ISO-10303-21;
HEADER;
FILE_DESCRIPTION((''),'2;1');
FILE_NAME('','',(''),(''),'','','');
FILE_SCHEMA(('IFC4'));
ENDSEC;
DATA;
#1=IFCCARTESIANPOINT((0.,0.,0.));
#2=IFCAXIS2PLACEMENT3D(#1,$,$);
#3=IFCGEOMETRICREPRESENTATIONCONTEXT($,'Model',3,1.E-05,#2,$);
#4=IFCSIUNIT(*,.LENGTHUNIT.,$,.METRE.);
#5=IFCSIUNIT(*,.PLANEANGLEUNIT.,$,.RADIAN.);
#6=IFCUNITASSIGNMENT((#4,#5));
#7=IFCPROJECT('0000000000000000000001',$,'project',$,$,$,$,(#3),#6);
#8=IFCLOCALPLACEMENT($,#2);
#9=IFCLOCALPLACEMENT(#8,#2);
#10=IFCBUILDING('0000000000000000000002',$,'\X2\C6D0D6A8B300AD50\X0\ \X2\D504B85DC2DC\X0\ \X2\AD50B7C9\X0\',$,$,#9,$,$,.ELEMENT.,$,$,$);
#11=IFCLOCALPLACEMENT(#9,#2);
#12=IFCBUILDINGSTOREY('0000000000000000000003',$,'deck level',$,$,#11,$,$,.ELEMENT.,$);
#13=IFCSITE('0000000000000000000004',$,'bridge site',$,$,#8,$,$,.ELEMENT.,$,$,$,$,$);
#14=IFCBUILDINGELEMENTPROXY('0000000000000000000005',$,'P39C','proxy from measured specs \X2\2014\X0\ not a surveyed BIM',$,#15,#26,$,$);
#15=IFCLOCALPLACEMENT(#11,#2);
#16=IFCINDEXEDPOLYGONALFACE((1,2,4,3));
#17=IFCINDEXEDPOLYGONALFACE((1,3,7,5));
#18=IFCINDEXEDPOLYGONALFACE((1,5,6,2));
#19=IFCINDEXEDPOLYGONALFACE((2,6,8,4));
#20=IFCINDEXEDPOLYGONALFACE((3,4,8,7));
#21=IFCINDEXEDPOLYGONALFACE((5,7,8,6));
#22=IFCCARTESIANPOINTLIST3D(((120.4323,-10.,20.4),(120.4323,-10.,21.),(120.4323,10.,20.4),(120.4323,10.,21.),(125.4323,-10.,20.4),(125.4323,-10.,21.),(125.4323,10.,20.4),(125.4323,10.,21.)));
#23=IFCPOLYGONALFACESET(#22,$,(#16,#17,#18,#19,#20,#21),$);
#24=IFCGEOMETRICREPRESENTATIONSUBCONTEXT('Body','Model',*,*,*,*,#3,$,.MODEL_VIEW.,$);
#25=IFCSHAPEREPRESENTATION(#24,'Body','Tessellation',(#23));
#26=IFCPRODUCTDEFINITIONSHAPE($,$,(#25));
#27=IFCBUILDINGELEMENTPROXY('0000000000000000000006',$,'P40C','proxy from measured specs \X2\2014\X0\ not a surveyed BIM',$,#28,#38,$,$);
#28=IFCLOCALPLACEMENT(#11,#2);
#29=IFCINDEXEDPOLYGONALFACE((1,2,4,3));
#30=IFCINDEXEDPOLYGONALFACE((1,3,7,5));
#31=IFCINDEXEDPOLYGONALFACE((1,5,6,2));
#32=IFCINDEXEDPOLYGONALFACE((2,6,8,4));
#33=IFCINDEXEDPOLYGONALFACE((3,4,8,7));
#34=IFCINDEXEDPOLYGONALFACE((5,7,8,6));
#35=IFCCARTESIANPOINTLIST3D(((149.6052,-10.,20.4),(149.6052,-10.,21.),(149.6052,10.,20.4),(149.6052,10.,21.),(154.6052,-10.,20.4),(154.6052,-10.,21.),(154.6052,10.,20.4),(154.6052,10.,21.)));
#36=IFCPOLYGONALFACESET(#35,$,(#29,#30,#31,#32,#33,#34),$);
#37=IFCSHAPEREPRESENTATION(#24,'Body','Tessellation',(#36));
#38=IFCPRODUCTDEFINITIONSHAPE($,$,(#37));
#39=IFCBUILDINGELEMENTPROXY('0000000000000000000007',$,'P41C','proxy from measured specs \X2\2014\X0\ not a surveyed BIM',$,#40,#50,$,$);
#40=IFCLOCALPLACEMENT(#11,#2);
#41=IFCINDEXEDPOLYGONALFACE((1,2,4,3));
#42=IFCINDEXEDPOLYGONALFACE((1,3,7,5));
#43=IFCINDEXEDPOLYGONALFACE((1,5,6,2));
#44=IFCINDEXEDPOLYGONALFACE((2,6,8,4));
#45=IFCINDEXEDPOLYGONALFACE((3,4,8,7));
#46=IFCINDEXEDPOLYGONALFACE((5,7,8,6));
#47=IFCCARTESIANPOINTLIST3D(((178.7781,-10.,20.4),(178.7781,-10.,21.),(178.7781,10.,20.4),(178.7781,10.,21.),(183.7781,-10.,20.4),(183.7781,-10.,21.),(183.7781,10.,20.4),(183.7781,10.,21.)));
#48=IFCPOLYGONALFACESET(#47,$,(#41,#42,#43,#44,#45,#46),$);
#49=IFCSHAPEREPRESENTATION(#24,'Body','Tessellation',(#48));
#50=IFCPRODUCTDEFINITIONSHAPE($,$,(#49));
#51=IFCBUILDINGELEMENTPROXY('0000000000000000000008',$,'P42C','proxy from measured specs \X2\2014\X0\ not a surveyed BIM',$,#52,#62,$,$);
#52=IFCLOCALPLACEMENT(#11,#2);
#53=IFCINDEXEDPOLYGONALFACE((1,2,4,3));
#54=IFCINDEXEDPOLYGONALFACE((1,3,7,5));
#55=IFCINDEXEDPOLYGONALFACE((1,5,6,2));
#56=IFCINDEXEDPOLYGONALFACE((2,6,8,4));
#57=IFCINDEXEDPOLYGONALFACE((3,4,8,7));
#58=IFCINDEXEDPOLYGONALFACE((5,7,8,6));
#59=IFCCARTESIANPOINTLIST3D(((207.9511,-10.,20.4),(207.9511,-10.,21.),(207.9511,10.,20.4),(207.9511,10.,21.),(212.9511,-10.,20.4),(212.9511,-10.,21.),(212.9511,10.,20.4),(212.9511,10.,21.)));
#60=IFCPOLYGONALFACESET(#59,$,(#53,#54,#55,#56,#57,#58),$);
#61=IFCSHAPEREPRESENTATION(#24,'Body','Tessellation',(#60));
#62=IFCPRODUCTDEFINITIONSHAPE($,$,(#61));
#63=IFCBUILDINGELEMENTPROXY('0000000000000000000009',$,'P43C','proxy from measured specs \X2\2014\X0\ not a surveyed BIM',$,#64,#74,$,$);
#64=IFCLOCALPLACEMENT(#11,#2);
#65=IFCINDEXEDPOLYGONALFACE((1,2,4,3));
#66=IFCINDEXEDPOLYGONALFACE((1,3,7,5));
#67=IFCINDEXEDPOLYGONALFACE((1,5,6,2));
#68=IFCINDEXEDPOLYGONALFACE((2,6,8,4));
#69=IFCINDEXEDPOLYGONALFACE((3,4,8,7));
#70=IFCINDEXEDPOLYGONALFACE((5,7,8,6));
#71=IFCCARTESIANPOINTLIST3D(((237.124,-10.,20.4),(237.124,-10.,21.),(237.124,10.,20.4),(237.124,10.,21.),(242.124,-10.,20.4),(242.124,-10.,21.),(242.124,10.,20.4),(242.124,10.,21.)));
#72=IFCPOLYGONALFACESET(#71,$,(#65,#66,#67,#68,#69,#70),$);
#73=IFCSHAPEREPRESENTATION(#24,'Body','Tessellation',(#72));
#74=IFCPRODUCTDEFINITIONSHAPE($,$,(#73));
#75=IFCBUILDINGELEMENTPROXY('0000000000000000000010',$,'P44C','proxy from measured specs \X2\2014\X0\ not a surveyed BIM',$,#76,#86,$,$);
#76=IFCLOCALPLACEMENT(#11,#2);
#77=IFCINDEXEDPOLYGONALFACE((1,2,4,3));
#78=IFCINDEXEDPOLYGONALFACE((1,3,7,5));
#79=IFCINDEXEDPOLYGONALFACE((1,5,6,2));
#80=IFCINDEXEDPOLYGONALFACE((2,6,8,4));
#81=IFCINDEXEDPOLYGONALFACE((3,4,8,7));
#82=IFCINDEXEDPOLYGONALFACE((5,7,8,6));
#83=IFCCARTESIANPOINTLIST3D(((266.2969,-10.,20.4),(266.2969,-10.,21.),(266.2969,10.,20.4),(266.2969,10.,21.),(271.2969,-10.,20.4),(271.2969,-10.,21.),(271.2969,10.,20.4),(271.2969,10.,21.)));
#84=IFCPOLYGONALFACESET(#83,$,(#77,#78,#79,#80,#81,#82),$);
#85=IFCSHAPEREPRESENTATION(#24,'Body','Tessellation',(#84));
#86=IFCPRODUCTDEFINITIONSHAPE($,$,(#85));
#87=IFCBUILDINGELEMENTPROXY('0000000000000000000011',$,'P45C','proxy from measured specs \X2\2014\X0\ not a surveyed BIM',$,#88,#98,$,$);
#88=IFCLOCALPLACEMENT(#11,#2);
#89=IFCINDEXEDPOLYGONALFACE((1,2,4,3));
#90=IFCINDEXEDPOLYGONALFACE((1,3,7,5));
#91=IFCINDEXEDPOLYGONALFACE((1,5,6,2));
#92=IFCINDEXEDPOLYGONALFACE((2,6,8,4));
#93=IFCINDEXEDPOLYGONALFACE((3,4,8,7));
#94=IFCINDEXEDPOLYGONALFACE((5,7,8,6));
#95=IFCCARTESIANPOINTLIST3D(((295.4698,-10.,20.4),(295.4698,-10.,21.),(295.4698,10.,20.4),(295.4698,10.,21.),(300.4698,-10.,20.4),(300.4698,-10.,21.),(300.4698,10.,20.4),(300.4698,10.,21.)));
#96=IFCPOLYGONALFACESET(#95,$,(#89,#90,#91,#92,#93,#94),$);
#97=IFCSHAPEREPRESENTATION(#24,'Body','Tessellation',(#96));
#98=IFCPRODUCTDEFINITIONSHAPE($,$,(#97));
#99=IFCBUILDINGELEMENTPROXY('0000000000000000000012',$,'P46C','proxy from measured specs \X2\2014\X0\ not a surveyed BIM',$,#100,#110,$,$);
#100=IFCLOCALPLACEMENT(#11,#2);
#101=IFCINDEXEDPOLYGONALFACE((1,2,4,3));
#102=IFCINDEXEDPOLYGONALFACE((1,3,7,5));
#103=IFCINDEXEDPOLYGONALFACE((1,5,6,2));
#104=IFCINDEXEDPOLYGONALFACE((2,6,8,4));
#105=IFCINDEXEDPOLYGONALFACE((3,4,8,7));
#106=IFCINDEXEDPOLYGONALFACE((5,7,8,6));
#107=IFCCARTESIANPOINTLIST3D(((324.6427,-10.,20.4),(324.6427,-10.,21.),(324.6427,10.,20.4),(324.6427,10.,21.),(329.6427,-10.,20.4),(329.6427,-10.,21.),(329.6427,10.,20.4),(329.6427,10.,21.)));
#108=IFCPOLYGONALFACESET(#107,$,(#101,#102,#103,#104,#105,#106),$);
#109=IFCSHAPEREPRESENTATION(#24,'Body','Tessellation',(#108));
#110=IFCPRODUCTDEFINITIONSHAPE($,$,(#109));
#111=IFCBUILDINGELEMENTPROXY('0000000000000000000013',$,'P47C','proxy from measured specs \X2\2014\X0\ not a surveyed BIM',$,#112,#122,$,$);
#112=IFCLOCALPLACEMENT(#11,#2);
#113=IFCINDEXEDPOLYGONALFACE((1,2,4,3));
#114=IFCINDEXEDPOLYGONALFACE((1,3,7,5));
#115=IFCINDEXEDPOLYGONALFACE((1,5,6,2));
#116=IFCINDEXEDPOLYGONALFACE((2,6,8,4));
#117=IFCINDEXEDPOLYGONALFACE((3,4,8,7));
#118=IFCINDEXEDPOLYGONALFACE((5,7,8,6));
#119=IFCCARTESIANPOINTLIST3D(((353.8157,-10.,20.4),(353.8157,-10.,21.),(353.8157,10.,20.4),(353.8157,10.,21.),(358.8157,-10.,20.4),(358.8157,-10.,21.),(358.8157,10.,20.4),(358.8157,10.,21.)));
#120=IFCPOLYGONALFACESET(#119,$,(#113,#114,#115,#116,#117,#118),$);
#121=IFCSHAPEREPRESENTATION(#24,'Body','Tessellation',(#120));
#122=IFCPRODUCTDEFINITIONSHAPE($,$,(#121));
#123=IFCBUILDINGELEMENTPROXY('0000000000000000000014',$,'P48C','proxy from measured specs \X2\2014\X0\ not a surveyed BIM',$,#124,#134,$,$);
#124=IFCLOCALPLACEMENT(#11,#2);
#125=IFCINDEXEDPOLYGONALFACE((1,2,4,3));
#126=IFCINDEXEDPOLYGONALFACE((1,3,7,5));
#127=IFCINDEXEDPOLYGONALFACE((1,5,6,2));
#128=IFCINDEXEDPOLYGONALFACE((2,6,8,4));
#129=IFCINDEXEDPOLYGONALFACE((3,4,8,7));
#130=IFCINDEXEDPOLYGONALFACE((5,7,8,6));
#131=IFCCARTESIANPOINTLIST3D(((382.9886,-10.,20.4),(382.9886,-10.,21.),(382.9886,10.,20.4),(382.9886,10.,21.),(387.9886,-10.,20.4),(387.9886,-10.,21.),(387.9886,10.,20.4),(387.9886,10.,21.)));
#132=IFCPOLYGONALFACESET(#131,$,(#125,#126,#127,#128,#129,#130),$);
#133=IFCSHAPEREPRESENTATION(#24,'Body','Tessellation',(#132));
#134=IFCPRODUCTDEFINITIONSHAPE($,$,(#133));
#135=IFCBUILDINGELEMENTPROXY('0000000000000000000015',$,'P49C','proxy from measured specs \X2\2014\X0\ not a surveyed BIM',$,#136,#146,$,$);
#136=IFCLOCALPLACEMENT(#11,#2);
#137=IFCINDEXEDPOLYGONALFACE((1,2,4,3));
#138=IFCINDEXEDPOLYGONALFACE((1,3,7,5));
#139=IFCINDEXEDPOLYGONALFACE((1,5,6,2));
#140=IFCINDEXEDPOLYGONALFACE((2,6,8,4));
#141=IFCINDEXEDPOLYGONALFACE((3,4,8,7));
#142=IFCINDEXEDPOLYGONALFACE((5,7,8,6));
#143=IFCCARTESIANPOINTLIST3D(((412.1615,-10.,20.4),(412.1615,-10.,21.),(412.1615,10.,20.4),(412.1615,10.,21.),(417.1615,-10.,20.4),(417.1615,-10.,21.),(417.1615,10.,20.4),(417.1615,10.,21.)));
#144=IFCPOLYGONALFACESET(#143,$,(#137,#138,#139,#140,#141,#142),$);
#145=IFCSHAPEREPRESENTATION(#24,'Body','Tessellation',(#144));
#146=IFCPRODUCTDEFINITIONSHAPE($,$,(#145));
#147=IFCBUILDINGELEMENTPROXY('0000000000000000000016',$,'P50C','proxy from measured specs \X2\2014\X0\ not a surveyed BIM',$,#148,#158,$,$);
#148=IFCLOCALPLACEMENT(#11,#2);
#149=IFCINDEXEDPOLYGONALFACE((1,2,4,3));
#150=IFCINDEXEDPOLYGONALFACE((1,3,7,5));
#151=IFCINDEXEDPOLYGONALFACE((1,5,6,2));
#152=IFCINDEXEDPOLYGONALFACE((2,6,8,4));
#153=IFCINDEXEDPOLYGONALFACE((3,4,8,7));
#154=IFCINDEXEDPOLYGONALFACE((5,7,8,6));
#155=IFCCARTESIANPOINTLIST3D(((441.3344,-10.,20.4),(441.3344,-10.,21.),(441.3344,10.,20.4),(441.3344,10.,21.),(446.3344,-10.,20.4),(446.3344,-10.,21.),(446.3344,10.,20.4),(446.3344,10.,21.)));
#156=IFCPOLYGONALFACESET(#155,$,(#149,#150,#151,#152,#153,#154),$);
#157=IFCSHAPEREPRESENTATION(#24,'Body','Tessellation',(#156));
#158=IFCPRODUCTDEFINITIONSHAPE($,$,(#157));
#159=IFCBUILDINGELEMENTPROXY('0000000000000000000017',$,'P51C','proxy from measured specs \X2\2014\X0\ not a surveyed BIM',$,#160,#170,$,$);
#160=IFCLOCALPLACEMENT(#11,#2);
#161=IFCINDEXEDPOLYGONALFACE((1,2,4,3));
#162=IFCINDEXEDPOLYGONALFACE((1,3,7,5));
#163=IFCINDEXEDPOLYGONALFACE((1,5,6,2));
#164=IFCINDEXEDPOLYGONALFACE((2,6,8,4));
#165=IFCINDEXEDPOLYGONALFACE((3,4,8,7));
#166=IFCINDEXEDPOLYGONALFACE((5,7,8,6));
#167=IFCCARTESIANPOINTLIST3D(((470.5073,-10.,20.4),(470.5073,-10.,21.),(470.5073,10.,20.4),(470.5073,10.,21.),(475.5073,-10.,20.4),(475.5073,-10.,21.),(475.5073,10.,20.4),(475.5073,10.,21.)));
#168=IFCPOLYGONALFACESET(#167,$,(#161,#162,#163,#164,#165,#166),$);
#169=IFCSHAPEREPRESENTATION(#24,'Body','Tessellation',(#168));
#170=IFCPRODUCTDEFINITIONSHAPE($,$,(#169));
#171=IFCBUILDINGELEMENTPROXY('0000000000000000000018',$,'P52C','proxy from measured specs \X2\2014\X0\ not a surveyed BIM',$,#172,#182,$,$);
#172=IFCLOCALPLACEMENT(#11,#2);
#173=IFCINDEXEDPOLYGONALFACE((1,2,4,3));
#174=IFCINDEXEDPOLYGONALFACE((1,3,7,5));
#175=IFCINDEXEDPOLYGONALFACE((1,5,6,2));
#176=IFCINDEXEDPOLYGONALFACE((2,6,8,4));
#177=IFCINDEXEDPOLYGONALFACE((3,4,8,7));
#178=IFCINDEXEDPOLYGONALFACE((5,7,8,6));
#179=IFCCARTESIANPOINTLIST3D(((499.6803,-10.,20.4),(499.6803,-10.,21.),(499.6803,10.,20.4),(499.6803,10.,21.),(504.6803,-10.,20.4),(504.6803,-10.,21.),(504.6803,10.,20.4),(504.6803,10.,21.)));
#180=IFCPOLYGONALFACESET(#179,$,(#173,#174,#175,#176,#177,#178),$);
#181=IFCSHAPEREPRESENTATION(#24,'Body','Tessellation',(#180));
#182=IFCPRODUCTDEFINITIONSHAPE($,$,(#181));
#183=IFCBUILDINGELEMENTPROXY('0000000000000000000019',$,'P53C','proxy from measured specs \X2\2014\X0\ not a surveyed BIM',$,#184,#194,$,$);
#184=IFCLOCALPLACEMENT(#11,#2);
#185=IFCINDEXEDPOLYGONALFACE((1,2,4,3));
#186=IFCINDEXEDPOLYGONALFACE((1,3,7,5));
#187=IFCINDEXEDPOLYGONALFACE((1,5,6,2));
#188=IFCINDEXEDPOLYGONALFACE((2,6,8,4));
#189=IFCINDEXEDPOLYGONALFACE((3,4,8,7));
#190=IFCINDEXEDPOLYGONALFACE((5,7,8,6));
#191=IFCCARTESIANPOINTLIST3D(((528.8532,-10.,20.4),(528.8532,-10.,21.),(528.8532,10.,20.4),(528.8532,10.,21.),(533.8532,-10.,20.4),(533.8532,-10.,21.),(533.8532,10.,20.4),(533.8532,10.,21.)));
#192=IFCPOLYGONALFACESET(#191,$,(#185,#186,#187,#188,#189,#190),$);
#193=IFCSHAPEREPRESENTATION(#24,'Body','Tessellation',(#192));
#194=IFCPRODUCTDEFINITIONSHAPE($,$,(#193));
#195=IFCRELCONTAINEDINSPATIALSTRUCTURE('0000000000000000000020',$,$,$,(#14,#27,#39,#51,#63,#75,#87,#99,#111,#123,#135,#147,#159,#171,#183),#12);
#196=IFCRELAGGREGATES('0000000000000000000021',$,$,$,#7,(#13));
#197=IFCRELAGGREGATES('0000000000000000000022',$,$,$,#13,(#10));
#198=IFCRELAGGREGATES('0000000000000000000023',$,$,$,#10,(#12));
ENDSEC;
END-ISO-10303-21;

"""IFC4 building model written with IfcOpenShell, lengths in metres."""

from ifc_helpers import new_model, si_unit, frame, origin, origin_2d, place, context, subcontext, project, spatial, rectangle, extrude, element, save


model = new_model("IFC4")

# Units and contexts
model_context = context("Model", 3, precision=1e-05, world=origin())
body_context = subcontext(model_context, "Body", "Model", "MODEL_VIEW")
ifc_project = project(units=[si_unit("LENGTHUNIT", "METRE"), si_unit("PLANEANGLEUNIT", "RADIAN")], contexts=[model_context])

# Site, building, storey
site_placement = place(None, origin())
site = spatial("IfcSite", under=ifc_project, at=site_placement, Name="bridge site", CompositionType="ELEMENT")
building_placement = place(site_placement, origin())
building = spatial("IfcBuilding", under=site, at=building_placement, Name="원효대교 프록시 교량", CompositionType="ELEMENT")
storey_placement = place(building_placement, origin())
storey = spatial("IfcBuildingStorey", under=building, at=storey_placement, Name="deck level", CompositionType="ELEMENT")

# Building element proxies
for number, where, name in (
    (1, (122.9323, 0.0, 20.4), "P39C"),
    (2, (152.1052, 0.0, 20.4), "P40C"),
    (3, (181.2781, 0.0, 20.4), "P41C"),
    (4, (210.4511, 0.0, 20.4), "P42C"),
    (5, (239.624, 0.0, 20.4), "P43C"),
    (6, (268.7969, 0.0, 20.4), "P44C"),
    (7, (297.9698, 0.0, 20.4), "P45C"),
    (8, (327.1427, 0.0, 20.4), "P46C"),
    (9, (356.3157, 0.0, 20.4), "P47C"),
    (10, (385.4886, 0.0, 20.4), "P48C"),
    (11, (414.6615, 0.0, 20.4), "P49C"),
    (12, (443.8344, 0.0, 20.4), "P50C"),
    (13, (473.0073, 0.0, 20.4), "P51C"),
    (14, (502.1803, 0.0, 20.4), "P52C"),
    (15, (531.3532, 0.0, 20.4), "P53C"),
):
    element("IfcBuildingElementProxy", number, at=place(storey_placement, frame(where)), inside=storey, Name=name, Description="proxy from measured specs — not a surveyed BIM", context=body_context, shape_type="SweptSolid", body=[
        extrude(rectangle(XDim=5.0, YDim=20.0, at=origin_2d()), origin(), (0.0, 0.0, 1.0), 0.6),
    ])

save(model, "model.ifc")
